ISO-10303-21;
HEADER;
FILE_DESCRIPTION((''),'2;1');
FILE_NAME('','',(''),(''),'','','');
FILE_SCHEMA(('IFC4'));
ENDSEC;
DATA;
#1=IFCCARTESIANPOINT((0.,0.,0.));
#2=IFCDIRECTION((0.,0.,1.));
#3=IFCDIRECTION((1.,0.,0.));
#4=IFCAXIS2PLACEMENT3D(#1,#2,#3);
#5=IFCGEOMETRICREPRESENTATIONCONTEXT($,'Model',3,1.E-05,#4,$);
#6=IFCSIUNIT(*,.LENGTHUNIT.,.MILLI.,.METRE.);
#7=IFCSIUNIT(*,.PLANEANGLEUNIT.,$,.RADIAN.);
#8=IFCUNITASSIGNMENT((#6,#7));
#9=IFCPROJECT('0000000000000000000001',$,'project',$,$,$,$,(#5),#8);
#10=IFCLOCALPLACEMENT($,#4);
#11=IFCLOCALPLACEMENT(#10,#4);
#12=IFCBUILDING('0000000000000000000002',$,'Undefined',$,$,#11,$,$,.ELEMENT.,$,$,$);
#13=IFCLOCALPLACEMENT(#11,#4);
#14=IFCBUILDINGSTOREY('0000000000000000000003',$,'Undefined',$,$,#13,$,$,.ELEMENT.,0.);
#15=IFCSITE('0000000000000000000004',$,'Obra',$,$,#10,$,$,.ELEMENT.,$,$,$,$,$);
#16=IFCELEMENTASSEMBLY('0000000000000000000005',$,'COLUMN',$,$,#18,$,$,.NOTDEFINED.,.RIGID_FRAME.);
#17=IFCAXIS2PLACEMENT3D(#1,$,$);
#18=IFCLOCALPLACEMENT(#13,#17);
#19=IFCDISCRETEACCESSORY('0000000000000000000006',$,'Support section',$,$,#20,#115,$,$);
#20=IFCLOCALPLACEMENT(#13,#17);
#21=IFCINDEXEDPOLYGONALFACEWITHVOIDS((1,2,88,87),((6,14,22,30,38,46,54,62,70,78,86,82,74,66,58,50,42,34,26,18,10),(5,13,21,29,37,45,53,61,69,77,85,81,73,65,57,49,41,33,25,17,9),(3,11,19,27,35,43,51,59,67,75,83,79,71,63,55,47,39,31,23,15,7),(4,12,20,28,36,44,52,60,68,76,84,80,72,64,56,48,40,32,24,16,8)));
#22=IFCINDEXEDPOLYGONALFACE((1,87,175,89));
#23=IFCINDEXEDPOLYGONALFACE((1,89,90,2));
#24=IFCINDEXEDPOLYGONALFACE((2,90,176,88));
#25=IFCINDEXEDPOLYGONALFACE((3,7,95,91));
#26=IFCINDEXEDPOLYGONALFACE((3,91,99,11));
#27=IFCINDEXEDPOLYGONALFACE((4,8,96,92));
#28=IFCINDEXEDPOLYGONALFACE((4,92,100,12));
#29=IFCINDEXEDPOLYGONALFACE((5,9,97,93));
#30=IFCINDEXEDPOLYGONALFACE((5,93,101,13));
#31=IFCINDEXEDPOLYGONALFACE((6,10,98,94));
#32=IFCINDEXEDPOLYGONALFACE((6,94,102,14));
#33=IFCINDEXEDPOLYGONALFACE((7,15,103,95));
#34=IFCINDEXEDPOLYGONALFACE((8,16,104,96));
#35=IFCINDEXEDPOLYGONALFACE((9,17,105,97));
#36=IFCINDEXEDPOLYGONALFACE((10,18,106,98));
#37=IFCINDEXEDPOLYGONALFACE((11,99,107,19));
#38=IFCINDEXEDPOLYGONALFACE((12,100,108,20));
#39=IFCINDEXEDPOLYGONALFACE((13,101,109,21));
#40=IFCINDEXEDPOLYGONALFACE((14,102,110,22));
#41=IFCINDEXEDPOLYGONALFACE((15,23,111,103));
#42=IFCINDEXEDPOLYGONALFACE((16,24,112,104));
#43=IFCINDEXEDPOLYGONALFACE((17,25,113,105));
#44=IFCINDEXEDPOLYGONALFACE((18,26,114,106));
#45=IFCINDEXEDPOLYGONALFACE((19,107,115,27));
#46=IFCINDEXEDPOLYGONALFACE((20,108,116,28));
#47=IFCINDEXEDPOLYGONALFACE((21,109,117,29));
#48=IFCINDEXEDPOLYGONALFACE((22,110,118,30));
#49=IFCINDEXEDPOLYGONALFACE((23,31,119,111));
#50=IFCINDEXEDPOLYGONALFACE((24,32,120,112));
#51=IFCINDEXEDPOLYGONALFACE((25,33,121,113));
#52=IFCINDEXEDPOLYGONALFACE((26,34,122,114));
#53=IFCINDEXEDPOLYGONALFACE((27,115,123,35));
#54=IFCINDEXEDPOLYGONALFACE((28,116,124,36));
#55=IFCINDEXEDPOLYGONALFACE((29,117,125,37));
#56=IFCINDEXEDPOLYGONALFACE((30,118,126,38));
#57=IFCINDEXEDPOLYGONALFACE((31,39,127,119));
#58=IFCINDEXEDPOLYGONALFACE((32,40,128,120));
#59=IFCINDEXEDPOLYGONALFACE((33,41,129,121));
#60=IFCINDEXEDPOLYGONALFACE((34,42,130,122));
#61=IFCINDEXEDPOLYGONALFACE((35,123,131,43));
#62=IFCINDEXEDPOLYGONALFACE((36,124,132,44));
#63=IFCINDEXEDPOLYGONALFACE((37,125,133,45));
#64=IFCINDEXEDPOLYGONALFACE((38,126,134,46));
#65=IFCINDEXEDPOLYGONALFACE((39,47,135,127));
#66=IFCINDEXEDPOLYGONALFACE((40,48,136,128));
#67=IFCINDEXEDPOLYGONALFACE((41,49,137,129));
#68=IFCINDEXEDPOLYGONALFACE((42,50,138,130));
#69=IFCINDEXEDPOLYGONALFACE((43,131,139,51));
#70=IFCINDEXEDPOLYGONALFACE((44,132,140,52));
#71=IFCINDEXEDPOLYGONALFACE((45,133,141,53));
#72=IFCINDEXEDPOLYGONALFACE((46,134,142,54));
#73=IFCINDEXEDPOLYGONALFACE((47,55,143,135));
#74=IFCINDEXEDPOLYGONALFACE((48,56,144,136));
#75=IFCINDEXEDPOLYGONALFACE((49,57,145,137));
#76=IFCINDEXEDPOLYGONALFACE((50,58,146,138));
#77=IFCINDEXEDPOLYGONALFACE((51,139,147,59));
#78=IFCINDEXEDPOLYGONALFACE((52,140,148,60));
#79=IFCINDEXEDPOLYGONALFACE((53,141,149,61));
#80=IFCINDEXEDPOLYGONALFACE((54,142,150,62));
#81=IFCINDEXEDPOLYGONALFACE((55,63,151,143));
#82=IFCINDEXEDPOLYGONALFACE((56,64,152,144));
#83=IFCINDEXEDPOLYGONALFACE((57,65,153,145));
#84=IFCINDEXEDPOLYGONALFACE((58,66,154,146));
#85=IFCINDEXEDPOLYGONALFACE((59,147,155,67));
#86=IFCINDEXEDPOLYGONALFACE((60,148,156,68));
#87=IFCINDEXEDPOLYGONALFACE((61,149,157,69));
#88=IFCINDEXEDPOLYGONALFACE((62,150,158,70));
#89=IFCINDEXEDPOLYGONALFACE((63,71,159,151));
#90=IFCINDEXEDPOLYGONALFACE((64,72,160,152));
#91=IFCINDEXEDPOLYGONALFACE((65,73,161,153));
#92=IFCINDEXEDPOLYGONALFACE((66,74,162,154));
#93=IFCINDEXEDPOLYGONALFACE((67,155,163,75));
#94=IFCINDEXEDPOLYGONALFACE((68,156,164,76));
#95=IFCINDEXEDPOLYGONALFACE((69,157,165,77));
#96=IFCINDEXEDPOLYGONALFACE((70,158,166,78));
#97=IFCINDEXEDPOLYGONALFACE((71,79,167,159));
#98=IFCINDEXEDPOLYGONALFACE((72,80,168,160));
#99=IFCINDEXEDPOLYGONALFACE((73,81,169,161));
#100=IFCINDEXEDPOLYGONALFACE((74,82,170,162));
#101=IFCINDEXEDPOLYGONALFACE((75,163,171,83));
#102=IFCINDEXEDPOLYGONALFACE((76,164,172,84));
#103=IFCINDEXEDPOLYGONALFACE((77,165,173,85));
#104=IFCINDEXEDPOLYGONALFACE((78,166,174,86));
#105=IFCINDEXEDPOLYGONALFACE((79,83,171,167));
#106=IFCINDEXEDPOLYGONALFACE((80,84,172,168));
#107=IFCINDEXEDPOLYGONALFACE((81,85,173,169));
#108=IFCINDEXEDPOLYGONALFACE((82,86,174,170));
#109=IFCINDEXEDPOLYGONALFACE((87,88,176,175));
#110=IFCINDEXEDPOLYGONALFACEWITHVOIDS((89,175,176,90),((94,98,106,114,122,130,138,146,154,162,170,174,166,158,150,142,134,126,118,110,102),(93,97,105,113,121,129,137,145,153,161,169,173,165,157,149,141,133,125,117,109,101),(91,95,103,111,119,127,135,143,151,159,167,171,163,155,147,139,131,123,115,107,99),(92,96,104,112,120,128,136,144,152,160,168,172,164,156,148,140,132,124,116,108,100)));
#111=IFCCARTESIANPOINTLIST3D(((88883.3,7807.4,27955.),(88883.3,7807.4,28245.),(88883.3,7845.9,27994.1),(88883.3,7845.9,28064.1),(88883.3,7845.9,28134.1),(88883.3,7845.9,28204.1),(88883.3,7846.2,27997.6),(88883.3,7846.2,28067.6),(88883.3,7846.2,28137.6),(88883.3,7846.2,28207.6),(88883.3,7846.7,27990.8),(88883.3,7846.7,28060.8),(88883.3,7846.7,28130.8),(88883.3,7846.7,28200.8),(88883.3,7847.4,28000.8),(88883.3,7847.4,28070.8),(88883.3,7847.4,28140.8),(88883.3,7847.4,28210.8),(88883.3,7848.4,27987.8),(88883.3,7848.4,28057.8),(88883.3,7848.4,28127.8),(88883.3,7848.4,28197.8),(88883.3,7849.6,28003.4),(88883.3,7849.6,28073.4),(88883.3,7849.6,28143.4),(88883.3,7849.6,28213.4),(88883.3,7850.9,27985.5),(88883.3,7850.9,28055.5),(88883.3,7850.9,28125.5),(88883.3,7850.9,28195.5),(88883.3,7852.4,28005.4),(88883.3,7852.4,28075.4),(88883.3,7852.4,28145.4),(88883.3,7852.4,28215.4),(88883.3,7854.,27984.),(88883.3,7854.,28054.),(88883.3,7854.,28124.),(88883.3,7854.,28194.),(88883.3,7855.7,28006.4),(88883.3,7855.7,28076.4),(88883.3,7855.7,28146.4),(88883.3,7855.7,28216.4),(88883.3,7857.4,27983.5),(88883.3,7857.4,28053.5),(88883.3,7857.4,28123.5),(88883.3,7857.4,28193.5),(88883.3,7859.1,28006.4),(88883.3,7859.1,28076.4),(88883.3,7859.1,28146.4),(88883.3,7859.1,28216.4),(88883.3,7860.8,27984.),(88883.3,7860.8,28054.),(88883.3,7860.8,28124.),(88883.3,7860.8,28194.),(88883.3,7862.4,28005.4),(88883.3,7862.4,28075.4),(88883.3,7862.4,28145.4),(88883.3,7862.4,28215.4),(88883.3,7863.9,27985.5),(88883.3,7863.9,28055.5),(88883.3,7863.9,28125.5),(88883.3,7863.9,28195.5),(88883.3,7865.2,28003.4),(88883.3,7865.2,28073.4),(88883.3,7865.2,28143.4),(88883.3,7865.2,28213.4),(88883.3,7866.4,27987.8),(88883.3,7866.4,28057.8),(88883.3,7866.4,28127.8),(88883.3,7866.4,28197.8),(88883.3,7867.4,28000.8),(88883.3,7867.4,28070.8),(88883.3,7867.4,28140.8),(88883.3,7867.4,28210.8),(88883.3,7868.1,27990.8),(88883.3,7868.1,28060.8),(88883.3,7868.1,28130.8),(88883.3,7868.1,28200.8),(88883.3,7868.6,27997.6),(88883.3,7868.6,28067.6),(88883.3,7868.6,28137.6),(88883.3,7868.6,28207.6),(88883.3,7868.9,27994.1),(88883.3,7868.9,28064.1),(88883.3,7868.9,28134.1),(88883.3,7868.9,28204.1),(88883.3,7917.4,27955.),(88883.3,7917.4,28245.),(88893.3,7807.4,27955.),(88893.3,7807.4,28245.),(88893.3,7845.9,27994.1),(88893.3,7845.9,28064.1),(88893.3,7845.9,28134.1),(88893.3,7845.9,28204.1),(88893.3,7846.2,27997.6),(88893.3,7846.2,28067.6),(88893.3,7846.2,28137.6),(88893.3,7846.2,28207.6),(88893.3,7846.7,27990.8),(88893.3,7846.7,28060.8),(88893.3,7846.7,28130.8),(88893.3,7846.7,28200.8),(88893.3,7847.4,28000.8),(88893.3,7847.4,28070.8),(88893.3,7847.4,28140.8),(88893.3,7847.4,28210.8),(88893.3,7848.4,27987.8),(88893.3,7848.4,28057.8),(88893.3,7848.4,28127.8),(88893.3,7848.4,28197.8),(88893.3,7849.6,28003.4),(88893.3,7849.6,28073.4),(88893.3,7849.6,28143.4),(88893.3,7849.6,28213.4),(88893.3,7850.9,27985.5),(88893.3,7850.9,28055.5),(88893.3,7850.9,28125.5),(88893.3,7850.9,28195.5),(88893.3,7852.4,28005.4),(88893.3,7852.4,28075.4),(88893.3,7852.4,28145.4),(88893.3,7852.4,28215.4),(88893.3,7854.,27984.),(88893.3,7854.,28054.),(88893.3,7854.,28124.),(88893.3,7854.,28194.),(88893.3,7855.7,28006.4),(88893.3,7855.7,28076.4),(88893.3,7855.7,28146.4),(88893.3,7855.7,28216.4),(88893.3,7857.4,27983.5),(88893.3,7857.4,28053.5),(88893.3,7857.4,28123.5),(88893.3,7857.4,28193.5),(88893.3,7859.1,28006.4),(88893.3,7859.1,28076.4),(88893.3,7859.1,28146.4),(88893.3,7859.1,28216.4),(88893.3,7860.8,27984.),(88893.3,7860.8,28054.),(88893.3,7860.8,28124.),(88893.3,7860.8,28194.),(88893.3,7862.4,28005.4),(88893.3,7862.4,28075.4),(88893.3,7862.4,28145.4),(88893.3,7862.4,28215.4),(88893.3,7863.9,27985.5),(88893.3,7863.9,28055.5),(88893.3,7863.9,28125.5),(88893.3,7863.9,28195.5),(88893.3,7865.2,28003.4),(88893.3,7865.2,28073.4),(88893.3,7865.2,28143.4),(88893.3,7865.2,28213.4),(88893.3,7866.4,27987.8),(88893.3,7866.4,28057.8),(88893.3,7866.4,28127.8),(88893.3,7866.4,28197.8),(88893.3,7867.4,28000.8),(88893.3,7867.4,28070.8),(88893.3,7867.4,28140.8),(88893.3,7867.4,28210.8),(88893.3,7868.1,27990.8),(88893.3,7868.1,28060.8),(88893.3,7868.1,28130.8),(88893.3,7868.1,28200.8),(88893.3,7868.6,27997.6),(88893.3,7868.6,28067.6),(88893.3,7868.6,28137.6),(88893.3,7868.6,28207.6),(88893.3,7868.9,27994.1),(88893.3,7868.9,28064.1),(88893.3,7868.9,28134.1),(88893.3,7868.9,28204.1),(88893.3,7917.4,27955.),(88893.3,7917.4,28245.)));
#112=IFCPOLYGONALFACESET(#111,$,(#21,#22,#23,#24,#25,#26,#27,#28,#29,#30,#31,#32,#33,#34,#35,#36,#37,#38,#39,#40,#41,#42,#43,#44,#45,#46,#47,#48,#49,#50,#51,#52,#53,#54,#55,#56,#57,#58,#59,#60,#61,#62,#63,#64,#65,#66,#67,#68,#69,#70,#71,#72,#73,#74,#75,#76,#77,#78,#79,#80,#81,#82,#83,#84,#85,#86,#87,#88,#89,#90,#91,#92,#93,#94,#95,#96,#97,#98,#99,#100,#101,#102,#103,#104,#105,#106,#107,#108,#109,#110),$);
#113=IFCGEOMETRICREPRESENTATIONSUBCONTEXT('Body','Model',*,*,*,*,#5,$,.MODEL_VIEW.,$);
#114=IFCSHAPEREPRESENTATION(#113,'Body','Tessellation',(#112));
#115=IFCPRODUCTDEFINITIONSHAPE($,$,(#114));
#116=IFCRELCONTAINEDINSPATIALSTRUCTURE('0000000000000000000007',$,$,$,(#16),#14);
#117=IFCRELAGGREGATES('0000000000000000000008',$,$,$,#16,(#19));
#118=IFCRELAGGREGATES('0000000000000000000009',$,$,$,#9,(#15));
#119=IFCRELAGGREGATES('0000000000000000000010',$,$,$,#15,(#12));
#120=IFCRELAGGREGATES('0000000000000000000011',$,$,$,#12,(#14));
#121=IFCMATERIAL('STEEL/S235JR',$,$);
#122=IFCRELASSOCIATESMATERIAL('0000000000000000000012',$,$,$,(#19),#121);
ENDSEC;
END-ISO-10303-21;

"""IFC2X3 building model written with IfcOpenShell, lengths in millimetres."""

from ifc_helpers import new_model, si_unit, frame, origin_with_axes, origin_2d_with_axis, place, context, subcontext, project, spatial, rectangle, circle, extrude, source, transform, mapped, material, element, aggregate, save


model = new_model("IFC2X3")

# Units and contexts
model_context = context("Model", 3, precision=1e-05, world=origin_with_axes())
body_context = subcontext(model_context, "Body", "Model", "MODEL_VIEW")
ifc_project = project(units=[si_unit("LENGTHUNIT", "METRE", prefix="MILLI"), si_unit("PLANEANGLEUNIT", "RADIAN")], contexts=[model_context])

# Site, building, storey
site_placement = place(None, origin_with_axes())
site = spatial("IfcSite", under=ifc_project, at=site_placement, Name="Obra", CompositionType="ELEMENT")
building_placement = place(site_placement, origin_with_axes())
building = spatial("IfcBuilding", under=site, at=building_placement, Name="Undefined", CompositionType="ELEMENT")
storey_placement = place(building_placement, origin_with_axes())
storey = spatial("IfcBuildingStorey", under=building, at=storey_placement, Name="Undefined", CompositionType="ELEMENT", Elevation=0.0)

# Element assembly
ifc_material = material(Name="STEEL/S235JR")
assembly_1_placement = place(storey_placement, origin_with_axes())
assembly_1 = element("IfcElementAssembly", 1, at=assembly_1_placement, inside=storey, Name="COLUMN", AssemblyPlace="NOTDEFINED", PredefinedType="RIGID_FRAME")

# Discrete accessory, opening
discrete_accessory_1_placement = place(assembly_1_placement, frame((88888.3, 7862.4, 27955.0), z_axis=(0.0, 0.0, 1.0), x_axis=(0.0, 1.0, 0.0)))
discrete_accessory_1 = element("IfcDiscreteAccessory", 2, at=discrete_accessory_1_placement, material=ifc_material, Name="Support section", context=body_context, shape_type="SweptSolid", body=[
    extrude(rectangle(XDim=10.0, YDim=110.0, at=origin_2d_with_axis()), frame((0.0, 0.0, 290.0), z_axis=(0.0, 0.0, -1.0), x_axis=(0.0, 1.0, 0.0)), (0.0, 0.0, 1.0), 290.0),
])
shared_shape_1 = source(origin_with_axes(), body_context, "Body", "SweptSolid", [
    extrude(circle(Radius=11.5, at=origin_2d_with_axis()), frame((0.0, -14.4, 0.0), z_axis=(0.0, 1.0, 0.0), x_axis=(1.0, 0.0, 0.0)), (0.0, 0.0, 1.0), 10.2),
])
opening_1_placement = place(assembly_1_placement, frame((88897.6, 7907.4, 28300.0), z_axis=(0.0, -1.0, 0.0), x_axis=(0.0, 0.0, -1.0)))
element("IfcOpeningElement", 3, at=opening_1_placement, cuts=discrete_accessory_1, ObjectType="Opening", context=body_context, shape_type="MappedRepresentation", body=[
    mapped(shared_shape_1, transform((95.0, 0.0, 50.0))),
    mapped(shared_shape_1, transform((165.0, 0.0, 50.0))),
    mapped(shared_shape_1, transform((235.0, 0.0, 50.0))),
    mapped(shared_shape_1, transform((305.0, 0.0, 50.0))),
])
aggregate(assembly_1, [discrete_accessory_1])

save(model, "model.ifc")
